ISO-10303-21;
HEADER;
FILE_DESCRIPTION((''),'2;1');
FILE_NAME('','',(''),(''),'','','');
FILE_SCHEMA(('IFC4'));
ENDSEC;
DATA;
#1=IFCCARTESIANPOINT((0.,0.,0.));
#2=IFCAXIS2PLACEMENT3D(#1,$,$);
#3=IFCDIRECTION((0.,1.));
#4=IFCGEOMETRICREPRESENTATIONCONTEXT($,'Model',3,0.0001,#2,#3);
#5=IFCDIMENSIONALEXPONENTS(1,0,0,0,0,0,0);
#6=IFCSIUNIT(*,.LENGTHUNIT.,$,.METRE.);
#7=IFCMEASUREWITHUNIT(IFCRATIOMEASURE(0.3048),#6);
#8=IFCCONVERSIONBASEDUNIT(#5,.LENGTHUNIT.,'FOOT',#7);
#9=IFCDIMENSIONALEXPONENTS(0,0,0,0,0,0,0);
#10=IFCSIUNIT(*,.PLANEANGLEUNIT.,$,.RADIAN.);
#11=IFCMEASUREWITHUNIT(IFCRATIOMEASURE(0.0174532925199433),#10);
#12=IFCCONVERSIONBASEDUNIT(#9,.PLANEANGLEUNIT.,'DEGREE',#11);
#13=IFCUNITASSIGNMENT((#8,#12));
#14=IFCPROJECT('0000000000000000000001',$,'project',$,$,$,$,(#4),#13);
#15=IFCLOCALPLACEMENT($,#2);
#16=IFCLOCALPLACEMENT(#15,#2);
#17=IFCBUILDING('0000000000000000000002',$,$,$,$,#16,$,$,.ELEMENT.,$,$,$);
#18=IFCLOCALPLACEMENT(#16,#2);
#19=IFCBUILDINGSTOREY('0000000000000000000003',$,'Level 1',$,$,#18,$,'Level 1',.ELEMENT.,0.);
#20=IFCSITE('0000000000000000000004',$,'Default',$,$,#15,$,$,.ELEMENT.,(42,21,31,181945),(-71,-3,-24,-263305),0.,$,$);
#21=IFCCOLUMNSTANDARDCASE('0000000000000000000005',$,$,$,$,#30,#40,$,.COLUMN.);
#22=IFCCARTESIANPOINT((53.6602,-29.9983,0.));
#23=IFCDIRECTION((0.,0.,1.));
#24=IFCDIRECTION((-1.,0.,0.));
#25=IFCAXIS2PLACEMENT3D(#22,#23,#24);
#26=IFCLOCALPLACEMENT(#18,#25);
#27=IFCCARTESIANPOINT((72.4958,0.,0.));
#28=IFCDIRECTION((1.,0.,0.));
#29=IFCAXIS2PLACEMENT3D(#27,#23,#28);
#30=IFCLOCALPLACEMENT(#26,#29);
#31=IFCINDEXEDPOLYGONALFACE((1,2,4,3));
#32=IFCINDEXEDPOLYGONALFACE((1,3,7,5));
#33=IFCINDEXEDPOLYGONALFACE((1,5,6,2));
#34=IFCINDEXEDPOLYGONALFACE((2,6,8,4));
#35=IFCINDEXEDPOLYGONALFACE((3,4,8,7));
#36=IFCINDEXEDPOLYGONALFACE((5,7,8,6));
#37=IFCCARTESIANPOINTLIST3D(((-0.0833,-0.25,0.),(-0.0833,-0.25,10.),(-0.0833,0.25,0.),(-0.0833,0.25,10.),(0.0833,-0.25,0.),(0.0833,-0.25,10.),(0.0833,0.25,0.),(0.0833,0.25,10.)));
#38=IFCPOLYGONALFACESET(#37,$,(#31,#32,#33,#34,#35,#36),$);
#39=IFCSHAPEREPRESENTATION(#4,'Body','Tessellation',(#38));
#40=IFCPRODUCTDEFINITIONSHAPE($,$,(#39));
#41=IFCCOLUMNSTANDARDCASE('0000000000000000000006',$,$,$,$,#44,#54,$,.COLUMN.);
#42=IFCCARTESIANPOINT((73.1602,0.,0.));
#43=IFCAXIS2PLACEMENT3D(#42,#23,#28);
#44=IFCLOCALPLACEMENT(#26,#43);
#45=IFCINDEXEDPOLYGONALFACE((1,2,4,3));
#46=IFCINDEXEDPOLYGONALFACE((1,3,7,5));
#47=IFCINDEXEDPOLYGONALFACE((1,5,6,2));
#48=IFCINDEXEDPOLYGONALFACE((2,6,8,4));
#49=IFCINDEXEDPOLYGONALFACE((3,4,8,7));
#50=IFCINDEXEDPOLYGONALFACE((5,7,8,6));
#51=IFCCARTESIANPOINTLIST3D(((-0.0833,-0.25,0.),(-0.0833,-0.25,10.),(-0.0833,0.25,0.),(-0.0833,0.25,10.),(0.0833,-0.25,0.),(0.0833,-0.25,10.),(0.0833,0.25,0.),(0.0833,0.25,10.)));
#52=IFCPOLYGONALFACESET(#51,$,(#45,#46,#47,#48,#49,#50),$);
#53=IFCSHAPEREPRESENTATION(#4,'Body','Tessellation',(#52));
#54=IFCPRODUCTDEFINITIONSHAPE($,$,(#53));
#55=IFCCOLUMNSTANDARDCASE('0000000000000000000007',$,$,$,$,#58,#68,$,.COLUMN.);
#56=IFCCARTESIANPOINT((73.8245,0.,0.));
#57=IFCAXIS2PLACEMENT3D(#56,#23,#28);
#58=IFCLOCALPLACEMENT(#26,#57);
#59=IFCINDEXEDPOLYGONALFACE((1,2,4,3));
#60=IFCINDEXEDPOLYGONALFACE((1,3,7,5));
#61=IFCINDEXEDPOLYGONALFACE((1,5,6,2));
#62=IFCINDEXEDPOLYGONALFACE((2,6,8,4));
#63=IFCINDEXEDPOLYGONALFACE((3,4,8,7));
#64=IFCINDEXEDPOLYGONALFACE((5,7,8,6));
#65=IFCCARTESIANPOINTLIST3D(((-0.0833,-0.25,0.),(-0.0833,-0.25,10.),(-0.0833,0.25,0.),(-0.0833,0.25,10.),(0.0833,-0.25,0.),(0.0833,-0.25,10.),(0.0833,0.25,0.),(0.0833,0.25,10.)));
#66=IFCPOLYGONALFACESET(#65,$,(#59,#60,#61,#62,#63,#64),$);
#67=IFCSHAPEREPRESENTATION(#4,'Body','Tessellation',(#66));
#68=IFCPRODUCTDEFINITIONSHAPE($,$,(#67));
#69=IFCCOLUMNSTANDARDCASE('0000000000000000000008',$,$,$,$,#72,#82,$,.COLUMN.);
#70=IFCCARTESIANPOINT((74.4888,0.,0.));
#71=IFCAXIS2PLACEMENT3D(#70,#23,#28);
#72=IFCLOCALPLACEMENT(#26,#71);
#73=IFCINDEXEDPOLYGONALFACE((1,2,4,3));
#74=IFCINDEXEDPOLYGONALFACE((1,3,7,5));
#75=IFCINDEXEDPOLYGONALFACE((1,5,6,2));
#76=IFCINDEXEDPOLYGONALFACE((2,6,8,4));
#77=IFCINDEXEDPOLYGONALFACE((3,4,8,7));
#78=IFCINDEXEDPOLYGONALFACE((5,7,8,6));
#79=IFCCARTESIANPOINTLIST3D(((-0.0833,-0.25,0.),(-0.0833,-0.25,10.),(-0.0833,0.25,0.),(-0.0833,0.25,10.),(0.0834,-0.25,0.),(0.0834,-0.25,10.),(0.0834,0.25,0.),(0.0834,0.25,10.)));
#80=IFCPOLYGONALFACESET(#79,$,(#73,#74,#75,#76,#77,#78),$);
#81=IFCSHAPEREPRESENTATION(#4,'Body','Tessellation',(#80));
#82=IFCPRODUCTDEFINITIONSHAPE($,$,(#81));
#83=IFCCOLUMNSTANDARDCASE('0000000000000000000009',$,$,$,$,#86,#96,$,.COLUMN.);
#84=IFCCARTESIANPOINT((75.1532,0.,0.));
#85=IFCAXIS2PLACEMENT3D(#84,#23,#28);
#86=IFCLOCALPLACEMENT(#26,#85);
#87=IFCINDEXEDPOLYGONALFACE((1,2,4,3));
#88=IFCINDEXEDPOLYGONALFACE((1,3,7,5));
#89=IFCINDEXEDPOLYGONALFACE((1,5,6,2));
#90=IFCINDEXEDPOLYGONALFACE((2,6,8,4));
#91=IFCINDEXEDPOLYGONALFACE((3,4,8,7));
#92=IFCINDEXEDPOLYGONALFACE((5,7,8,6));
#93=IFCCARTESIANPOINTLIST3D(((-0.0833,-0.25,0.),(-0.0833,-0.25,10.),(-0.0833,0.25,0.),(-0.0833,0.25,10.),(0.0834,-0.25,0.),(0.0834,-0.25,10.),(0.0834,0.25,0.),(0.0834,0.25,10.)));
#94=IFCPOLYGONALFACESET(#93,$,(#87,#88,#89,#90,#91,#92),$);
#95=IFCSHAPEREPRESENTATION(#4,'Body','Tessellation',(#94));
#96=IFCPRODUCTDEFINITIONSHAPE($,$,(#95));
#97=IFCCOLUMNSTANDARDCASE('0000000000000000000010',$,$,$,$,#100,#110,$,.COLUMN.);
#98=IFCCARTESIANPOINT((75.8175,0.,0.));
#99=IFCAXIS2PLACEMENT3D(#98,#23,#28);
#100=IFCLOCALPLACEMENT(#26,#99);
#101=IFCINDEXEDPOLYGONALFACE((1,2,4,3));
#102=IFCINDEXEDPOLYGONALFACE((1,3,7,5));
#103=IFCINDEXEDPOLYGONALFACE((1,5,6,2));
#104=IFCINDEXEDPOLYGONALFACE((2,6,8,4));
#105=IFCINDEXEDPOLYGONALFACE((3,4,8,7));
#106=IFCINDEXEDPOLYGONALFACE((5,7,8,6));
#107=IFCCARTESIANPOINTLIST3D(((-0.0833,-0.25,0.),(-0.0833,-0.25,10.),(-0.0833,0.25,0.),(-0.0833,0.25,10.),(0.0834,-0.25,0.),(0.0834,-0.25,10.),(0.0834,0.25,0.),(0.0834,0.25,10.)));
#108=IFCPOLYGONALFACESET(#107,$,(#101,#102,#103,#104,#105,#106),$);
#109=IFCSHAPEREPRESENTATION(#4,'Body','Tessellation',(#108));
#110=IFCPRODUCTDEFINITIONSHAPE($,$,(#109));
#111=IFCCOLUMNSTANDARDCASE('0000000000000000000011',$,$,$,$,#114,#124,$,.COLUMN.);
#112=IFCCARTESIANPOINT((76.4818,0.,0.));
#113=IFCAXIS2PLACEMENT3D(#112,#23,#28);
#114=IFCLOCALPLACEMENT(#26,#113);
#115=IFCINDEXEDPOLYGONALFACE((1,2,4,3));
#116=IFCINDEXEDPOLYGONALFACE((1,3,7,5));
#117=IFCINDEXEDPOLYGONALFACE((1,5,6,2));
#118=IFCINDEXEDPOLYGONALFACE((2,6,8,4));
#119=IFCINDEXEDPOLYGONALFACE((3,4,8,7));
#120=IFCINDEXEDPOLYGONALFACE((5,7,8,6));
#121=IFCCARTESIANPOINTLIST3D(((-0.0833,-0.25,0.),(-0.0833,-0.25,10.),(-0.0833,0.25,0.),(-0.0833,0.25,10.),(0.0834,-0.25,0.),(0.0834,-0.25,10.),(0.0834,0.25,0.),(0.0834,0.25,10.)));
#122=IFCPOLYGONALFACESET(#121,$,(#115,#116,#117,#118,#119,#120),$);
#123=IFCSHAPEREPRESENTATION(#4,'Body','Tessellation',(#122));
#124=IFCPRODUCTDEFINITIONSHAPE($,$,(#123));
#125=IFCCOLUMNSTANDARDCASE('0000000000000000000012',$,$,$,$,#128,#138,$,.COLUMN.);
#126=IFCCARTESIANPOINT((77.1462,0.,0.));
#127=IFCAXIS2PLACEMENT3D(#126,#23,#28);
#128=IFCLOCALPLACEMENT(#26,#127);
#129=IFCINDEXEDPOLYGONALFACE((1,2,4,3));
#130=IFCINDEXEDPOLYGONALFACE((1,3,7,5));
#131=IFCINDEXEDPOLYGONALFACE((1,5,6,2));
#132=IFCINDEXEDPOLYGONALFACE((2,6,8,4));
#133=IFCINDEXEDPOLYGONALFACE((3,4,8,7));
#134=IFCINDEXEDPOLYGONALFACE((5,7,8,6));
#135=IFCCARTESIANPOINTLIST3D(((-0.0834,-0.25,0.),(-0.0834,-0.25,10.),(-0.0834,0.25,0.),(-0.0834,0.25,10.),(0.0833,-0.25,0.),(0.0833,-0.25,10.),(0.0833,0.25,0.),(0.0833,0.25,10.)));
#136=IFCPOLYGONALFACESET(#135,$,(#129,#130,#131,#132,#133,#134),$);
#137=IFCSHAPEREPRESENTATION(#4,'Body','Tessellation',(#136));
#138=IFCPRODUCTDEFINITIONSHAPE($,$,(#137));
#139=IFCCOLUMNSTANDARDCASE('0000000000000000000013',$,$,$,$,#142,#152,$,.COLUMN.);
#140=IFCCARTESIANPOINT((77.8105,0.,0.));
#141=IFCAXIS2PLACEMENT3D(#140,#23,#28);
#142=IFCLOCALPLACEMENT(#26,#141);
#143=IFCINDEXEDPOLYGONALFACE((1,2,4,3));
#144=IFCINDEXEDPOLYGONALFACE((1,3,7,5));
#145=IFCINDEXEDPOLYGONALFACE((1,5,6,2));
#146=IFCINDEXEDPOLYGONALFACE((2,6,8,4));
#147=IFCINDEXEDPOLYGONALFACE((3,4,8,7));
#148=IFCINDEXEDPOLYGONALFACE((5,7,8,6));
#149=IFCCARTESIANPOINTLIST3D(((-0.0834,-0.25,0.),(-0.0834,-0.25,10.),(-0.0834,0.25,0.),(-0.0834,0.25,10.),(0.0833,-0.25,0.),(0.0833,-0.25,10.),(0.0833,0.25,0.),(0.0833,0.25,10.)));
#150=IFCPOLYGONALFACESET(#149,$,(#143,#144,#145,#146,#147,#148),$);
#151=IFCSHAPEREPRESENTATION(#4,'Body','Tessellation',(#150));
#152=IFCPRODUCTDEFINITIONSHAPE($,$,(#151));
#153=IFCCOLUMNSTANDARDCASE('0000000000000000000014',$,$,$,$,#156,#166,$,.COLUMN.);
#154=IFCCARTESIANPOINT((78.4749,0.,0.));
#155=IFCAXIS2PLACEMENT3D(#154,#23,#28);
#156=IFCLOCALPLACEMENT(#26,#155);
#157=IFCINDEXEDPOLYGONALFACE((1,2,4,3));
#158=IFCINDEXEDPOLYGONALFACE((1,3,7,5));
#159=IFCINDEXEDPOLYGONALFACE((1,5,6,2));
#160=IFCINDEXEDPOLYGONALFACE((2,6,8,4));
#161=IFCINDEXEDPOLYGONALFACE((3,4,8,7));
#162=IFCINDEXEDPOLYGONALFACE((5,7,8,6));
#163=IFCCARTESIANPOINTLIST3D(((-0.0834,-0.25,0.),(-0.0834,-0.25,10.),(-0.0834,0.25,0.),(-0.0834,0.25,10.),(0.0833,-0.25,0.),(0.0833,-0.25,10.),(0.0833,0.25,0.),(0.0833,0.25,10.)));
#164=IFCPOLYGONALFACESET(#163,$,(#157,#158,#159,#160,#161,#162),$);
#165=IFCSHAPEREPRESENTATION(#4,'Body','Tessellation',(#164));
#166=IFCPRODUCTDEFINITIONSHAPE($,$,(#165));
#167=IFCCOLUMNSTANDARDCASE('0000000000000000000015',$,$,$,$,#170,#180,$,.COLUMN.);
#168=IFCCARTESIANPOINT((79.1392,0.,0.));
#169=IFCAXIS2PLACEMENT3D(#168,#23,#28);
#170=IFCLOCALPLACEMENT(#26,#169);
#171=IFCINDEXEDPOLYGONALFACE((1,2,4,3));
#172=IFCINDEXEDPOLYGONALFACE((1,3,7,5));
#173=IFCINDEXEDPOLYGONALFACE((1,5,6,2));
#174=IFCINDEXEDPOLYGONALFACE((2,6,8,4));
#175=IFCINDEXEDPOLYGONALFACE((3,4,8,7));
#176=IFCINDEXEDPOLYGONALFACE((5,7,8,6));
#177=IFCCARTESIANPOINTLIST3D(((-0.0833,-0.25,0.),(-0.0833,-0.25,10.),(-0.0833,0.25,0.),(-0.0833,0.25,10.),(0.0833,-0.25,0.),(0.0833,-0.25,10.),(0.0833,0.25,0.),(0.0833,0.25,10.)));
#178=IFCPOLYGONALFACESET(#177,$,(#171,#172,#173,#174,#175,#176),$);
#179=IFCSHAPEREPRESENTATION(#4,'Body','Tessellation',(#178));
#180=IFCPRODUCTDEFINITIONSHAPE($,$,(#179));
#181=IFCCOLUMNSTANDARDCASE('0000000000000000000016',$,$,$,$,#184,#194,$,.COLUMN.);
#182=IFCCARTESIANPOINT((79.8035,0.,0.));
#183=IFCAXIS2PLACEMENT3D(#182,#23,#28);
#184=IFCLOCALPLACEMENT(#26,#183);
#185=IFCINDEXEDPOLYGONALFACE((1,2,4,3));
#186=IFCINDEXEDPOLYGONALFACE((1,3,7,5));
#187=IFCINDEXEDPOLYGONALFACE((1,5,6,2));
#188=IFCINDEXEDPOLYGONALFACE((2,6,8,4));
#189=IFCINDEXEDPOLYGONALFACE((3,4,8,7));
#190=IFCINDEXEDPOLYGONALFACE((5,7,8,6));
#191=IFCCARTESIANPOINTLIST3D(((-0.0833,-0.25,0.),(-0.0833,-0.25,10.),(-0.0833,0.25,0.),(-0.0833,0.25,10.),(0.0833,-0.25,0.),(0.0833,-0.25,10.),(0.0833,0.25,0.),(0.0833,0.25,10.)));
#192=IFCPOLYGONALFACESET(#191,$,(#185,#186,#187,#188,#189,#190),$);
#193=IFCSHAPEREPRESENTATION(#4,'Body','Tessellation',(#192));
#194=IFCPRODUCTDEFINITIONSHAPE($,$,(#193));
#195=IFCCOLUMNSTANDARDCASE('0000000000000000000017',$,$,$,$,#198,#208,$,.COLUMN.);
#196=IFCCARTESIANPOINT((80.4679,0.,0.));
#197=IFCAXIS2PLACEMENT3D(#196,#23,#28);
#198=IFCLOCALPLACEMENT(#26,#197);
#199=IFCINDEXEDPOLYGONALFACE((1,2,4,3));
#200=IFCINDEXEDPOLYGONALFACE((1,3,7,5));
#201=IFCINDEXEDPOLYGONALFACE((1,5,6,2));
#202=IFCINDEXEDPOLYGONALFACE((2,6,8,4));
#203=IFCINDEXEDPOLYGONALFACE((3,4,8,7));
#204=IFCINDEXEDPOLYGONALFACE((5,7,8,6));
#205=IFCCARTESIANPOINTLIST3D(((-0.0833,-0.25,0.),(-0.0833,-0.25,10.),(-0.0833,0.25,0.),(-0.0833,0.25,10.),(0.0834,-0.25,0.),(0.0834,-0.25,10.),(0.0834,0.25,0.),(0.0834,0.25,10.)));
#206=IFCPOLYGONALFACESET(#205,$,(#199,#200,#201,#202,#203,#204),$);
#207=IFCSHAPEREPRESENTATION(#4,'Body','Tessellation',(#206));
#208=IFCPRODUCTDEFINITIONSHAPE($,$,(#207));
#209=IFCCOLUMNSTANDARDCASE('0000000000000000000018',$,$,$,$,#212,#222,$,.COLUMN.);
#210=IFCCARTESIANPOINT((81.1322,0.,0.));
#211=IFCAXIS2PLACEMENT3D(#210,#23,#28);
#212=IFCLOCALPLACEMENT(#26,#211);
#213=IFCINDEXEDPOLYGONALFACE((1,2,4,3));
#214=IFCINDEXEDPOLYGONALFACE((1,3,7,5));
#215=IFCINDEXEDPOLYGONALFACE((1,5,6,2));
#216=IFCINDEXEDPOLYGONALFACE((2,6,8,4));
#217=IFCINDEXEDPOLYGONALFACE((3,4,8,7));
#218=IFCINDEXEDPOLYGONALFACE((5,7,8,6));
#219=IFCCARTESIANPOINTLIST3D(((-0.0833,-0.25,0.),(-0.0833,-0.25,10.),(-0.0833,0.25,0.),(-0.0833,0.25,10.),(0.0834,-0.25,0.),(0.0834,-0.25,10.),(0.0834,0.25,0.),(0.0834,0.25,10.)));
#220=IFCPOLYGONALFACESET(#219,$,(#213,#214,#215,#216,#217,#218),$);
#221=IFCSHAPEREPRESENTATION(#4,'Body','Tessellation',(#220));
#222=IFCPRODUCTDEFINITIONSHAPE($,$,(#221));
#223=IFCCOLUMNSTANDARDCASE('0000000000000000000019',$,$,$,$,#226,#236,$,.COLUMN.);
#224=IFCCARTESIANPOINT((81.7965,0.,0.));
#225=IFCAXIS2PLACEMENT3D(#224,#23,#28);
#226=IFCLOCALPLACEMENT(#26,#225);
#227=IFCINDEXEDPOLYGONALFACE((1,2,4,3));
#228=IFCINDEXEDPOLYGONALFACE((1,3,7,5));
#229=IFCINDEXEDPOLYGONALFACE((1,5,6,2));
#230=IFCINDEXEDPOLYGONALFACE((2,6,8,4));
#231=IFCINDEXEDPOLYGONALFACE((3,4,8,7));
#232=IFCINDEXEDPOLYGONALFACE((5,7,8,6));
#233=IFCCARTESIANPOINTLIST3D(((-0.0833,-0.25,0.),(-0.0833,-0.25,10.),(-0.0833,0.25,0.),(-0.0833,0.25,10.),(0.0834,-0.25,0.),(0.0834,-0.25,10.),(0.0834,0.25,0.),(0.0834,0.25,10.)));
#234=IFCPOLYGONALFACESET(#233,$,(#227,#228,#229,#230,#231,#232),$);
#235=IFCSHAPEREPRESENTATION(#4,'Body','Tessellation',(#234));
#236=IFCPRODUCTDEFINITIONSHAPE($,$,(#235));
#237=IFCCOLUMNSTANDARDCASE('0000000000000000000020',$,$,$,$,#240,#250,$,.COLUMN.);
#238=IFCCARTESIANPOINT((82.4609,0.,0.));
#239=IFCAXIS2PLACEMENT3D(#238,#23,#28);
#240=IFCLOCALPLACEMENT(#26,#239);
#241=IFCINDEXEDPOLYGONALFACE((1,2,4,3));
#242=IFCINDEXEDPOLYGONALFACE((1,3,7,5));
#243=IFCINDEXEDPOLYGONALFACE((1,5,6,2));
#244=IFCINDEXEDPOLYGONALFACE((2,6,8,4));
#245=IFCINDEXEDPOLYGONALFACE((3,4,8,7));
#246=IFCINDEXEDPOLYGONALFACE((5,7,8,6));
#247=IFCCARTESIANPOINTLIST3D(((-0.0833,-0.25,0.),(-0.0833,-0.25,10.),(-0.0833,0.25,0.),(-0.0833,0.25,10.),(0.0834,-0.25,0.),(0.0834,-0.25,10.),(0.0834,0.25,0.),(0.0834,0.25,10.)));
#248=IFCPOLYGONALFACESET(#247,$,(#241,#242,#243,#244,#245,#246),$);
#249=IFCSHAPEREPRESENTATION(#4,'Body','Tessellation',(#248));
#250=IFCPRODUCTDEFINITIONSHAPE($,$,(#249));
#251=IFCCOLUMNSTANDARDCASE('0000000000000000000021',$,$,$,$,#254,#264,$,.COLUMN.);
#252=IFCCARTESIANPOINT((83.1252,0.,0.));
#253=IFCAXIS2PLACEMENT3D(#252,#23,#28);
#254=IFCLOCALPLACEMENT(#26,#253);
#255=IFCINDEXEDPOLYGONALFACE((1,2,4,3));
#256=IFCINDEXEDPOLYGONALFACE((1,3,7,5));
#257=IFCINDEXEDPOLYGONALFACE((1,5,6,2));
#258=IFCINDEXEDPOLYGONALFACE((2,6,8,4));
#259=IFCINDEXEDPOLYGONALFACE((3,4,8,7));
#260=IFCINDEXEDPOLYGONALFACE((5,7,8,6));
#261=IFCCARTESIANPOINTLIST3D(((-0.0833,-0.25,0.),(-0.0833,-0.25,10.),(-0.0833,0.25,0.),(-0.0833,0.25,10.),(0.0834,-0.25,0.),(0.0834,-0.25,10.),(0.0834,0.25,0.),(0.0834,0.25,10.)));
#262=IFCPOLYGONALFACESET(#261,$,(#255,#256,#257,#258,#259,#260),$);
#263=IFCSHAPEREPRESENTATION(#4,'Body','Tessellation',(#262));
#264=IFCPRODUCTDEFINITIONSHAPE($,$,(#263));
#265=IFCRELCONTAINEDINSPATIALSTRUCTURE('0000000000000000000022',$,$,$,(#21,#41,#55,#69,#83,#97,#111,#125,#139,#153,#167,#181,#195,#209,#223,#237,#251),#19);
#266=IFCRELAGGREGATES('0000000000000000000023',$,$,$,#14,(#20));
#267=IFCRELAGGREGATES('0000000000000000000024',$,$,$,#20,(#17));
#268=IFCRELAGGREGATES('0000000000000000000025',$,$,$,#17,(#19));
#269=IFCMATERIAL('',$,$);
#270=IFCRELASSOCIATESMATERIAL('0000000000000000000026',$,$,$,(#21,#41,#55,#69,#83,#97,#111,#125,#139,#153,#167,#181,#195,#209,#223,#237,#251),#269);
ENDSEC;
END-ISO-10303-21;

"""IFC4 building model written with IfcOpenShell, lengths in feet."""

from ifc_helpers import new_model, entity, si_unit, converted_unit, direction, frame, origin, place, context, project, spatial, rectangle, extrude, material, element, save


model = new_model("IFC4")

# Units and contexts
model_context = context("Model", 3, precision=0.0001, world=origin(), true_north=direction((0.0, 1.0)))
ifc_project = project(units=[converted_unit("LENGTHUNIT", "FOOT", entity("IfcRatioMeasure", 0.3048), si_unit("LENGTHUNIT", "METRE"), dimensions=[1, 0, 0, 0, 0, 0, 0]), converted_unit("PLANEANGLEUNIT", "DEGREE", entity("IfcRatioMeasure", 0.0174532925199433), si_unit("PLANEANGLEUNIT", "RADIAN"), dimensions=[0, 0, 0, 0, 0, 0, 0])], contexts=[model_context])

# Site, building, storey
site_placement = place(None, origin())
site = spatial("IfcSite", under=ifc_project, at=site_placement, Name="Default", CompositionType="ELEMENT", RefLatitude=(42, 21, 31, 181945), RefLongitude=(-71, -3, -24, -263305), RefElevation=0.0)
building_placement = place(site_placement, origin())
building = spatial("IfcBuilding", under=site, at=building_placement, CompositionType="ELEMENT")
storey_placement = place(building_placement, origin())
storey = spatial("IfcBuildingStorey", under=building, at=storey_placement, Name="Level 1", LongName="Level 1", CompositionType="ELEMENT", Elevation=0.0)

# Columns
ifc_material = material(Name="")
placement = place(storey_placement, frame((53.6602, -29.9983, 0.0), z_axis=(0.0, 0.0, 1.0), x_axis=(-1.0, 0.0, 0.0)))
for number, where, z_axis, x_axis in (
    (1, (72.4958, 0.0, 0.0), (0.0, 0.0, 1.0), (1.0, 0.0, 0.0)),
    (2, (73.1602, 0.0, 0.0), (0.0, 0.0, 1.0), (1.0, 0.0, 0.0)),
    (3, (73.8245, 0.0, 0.0), (0.0, 0.0, 1.0), (1.0, 0.0, 0.0)),
    (4, (74.4888, 0.0, 0.0), (0.0, 0.0, 1.0), (1.0, 0.0, 0.0)),
    (5, (75.1532, 0.0, 0.0), (0.0, 0.0, 1.0), (1.0, 0.0, 0.0)),
    (6, (75.8175, 0.0, 0.0), (0.0, 0.0, 1.0), (1.0, 0.0, 0.0)),
    (7, (76.4818, 0.0, 0.0), (0.0, 0.0, 1.0), (1.0, 0.0, 0.0)),
    (8, (77.1462, 0.0, 0.0), (0.0, 0.0, 1.0), (1.0, 0.0, 0.0)),
    (9, (77.8105, 0.0, 0.0), (0.0, 0.0, 1.0), (1.0, 0.0, 0.0)),
    (10, (78.4749, 0.0, 0.0), (0.0, 0.0, 1.0), (1.0, 0.0, 0.0)),
    (11, (79.1392, 0.0, 0.0), (0.0, 0.0, 1.0), (1.0, 0.0, 0.0)),
    (12, (79.8035, 0.0, 0.0), (0.0, 0.0, 1.0), (1.0, 0.0, 0.0)),
    (13, (80.4679, 0.0, 0.0), (0.0, 0.0, 1.0), (1.0, 0.0, 0.0)),
    (14, (81.1322, 0.0, 0.0), (0.0, 0.0, 1.0), (1.0, 0.0, 0.0)),
    (15, (81.7965, 0.0, 0.0), (0.0, 0.0, 1.0), (1.0, 0.0, 0.0)),
    (16, (82.4609, 0.0, 0.0), (0.0, 0.0, 1.0), (1.0, 0.0, 0.0)),
    (17, (83.1252, 0.0, 0.0), (0.0, 0.0, 1.0), (1.0, 0.0, 0.0)),
):
    element("IfcColumnStandardCase", number, at=place(placement, frame(where, z_axis=z_axis, x_axis=x_axis)), inside=storey, material=ifc_material, PredefinedType="COLUMN", context=model_context, shape_type="SweptSolid", body=[
        extrude(rectangle(XDim=0.1667, YDim=0.5), origin(), (0.0, 0.0, 1.0), 10.0),
    ])

save(model, "model.ifc")
